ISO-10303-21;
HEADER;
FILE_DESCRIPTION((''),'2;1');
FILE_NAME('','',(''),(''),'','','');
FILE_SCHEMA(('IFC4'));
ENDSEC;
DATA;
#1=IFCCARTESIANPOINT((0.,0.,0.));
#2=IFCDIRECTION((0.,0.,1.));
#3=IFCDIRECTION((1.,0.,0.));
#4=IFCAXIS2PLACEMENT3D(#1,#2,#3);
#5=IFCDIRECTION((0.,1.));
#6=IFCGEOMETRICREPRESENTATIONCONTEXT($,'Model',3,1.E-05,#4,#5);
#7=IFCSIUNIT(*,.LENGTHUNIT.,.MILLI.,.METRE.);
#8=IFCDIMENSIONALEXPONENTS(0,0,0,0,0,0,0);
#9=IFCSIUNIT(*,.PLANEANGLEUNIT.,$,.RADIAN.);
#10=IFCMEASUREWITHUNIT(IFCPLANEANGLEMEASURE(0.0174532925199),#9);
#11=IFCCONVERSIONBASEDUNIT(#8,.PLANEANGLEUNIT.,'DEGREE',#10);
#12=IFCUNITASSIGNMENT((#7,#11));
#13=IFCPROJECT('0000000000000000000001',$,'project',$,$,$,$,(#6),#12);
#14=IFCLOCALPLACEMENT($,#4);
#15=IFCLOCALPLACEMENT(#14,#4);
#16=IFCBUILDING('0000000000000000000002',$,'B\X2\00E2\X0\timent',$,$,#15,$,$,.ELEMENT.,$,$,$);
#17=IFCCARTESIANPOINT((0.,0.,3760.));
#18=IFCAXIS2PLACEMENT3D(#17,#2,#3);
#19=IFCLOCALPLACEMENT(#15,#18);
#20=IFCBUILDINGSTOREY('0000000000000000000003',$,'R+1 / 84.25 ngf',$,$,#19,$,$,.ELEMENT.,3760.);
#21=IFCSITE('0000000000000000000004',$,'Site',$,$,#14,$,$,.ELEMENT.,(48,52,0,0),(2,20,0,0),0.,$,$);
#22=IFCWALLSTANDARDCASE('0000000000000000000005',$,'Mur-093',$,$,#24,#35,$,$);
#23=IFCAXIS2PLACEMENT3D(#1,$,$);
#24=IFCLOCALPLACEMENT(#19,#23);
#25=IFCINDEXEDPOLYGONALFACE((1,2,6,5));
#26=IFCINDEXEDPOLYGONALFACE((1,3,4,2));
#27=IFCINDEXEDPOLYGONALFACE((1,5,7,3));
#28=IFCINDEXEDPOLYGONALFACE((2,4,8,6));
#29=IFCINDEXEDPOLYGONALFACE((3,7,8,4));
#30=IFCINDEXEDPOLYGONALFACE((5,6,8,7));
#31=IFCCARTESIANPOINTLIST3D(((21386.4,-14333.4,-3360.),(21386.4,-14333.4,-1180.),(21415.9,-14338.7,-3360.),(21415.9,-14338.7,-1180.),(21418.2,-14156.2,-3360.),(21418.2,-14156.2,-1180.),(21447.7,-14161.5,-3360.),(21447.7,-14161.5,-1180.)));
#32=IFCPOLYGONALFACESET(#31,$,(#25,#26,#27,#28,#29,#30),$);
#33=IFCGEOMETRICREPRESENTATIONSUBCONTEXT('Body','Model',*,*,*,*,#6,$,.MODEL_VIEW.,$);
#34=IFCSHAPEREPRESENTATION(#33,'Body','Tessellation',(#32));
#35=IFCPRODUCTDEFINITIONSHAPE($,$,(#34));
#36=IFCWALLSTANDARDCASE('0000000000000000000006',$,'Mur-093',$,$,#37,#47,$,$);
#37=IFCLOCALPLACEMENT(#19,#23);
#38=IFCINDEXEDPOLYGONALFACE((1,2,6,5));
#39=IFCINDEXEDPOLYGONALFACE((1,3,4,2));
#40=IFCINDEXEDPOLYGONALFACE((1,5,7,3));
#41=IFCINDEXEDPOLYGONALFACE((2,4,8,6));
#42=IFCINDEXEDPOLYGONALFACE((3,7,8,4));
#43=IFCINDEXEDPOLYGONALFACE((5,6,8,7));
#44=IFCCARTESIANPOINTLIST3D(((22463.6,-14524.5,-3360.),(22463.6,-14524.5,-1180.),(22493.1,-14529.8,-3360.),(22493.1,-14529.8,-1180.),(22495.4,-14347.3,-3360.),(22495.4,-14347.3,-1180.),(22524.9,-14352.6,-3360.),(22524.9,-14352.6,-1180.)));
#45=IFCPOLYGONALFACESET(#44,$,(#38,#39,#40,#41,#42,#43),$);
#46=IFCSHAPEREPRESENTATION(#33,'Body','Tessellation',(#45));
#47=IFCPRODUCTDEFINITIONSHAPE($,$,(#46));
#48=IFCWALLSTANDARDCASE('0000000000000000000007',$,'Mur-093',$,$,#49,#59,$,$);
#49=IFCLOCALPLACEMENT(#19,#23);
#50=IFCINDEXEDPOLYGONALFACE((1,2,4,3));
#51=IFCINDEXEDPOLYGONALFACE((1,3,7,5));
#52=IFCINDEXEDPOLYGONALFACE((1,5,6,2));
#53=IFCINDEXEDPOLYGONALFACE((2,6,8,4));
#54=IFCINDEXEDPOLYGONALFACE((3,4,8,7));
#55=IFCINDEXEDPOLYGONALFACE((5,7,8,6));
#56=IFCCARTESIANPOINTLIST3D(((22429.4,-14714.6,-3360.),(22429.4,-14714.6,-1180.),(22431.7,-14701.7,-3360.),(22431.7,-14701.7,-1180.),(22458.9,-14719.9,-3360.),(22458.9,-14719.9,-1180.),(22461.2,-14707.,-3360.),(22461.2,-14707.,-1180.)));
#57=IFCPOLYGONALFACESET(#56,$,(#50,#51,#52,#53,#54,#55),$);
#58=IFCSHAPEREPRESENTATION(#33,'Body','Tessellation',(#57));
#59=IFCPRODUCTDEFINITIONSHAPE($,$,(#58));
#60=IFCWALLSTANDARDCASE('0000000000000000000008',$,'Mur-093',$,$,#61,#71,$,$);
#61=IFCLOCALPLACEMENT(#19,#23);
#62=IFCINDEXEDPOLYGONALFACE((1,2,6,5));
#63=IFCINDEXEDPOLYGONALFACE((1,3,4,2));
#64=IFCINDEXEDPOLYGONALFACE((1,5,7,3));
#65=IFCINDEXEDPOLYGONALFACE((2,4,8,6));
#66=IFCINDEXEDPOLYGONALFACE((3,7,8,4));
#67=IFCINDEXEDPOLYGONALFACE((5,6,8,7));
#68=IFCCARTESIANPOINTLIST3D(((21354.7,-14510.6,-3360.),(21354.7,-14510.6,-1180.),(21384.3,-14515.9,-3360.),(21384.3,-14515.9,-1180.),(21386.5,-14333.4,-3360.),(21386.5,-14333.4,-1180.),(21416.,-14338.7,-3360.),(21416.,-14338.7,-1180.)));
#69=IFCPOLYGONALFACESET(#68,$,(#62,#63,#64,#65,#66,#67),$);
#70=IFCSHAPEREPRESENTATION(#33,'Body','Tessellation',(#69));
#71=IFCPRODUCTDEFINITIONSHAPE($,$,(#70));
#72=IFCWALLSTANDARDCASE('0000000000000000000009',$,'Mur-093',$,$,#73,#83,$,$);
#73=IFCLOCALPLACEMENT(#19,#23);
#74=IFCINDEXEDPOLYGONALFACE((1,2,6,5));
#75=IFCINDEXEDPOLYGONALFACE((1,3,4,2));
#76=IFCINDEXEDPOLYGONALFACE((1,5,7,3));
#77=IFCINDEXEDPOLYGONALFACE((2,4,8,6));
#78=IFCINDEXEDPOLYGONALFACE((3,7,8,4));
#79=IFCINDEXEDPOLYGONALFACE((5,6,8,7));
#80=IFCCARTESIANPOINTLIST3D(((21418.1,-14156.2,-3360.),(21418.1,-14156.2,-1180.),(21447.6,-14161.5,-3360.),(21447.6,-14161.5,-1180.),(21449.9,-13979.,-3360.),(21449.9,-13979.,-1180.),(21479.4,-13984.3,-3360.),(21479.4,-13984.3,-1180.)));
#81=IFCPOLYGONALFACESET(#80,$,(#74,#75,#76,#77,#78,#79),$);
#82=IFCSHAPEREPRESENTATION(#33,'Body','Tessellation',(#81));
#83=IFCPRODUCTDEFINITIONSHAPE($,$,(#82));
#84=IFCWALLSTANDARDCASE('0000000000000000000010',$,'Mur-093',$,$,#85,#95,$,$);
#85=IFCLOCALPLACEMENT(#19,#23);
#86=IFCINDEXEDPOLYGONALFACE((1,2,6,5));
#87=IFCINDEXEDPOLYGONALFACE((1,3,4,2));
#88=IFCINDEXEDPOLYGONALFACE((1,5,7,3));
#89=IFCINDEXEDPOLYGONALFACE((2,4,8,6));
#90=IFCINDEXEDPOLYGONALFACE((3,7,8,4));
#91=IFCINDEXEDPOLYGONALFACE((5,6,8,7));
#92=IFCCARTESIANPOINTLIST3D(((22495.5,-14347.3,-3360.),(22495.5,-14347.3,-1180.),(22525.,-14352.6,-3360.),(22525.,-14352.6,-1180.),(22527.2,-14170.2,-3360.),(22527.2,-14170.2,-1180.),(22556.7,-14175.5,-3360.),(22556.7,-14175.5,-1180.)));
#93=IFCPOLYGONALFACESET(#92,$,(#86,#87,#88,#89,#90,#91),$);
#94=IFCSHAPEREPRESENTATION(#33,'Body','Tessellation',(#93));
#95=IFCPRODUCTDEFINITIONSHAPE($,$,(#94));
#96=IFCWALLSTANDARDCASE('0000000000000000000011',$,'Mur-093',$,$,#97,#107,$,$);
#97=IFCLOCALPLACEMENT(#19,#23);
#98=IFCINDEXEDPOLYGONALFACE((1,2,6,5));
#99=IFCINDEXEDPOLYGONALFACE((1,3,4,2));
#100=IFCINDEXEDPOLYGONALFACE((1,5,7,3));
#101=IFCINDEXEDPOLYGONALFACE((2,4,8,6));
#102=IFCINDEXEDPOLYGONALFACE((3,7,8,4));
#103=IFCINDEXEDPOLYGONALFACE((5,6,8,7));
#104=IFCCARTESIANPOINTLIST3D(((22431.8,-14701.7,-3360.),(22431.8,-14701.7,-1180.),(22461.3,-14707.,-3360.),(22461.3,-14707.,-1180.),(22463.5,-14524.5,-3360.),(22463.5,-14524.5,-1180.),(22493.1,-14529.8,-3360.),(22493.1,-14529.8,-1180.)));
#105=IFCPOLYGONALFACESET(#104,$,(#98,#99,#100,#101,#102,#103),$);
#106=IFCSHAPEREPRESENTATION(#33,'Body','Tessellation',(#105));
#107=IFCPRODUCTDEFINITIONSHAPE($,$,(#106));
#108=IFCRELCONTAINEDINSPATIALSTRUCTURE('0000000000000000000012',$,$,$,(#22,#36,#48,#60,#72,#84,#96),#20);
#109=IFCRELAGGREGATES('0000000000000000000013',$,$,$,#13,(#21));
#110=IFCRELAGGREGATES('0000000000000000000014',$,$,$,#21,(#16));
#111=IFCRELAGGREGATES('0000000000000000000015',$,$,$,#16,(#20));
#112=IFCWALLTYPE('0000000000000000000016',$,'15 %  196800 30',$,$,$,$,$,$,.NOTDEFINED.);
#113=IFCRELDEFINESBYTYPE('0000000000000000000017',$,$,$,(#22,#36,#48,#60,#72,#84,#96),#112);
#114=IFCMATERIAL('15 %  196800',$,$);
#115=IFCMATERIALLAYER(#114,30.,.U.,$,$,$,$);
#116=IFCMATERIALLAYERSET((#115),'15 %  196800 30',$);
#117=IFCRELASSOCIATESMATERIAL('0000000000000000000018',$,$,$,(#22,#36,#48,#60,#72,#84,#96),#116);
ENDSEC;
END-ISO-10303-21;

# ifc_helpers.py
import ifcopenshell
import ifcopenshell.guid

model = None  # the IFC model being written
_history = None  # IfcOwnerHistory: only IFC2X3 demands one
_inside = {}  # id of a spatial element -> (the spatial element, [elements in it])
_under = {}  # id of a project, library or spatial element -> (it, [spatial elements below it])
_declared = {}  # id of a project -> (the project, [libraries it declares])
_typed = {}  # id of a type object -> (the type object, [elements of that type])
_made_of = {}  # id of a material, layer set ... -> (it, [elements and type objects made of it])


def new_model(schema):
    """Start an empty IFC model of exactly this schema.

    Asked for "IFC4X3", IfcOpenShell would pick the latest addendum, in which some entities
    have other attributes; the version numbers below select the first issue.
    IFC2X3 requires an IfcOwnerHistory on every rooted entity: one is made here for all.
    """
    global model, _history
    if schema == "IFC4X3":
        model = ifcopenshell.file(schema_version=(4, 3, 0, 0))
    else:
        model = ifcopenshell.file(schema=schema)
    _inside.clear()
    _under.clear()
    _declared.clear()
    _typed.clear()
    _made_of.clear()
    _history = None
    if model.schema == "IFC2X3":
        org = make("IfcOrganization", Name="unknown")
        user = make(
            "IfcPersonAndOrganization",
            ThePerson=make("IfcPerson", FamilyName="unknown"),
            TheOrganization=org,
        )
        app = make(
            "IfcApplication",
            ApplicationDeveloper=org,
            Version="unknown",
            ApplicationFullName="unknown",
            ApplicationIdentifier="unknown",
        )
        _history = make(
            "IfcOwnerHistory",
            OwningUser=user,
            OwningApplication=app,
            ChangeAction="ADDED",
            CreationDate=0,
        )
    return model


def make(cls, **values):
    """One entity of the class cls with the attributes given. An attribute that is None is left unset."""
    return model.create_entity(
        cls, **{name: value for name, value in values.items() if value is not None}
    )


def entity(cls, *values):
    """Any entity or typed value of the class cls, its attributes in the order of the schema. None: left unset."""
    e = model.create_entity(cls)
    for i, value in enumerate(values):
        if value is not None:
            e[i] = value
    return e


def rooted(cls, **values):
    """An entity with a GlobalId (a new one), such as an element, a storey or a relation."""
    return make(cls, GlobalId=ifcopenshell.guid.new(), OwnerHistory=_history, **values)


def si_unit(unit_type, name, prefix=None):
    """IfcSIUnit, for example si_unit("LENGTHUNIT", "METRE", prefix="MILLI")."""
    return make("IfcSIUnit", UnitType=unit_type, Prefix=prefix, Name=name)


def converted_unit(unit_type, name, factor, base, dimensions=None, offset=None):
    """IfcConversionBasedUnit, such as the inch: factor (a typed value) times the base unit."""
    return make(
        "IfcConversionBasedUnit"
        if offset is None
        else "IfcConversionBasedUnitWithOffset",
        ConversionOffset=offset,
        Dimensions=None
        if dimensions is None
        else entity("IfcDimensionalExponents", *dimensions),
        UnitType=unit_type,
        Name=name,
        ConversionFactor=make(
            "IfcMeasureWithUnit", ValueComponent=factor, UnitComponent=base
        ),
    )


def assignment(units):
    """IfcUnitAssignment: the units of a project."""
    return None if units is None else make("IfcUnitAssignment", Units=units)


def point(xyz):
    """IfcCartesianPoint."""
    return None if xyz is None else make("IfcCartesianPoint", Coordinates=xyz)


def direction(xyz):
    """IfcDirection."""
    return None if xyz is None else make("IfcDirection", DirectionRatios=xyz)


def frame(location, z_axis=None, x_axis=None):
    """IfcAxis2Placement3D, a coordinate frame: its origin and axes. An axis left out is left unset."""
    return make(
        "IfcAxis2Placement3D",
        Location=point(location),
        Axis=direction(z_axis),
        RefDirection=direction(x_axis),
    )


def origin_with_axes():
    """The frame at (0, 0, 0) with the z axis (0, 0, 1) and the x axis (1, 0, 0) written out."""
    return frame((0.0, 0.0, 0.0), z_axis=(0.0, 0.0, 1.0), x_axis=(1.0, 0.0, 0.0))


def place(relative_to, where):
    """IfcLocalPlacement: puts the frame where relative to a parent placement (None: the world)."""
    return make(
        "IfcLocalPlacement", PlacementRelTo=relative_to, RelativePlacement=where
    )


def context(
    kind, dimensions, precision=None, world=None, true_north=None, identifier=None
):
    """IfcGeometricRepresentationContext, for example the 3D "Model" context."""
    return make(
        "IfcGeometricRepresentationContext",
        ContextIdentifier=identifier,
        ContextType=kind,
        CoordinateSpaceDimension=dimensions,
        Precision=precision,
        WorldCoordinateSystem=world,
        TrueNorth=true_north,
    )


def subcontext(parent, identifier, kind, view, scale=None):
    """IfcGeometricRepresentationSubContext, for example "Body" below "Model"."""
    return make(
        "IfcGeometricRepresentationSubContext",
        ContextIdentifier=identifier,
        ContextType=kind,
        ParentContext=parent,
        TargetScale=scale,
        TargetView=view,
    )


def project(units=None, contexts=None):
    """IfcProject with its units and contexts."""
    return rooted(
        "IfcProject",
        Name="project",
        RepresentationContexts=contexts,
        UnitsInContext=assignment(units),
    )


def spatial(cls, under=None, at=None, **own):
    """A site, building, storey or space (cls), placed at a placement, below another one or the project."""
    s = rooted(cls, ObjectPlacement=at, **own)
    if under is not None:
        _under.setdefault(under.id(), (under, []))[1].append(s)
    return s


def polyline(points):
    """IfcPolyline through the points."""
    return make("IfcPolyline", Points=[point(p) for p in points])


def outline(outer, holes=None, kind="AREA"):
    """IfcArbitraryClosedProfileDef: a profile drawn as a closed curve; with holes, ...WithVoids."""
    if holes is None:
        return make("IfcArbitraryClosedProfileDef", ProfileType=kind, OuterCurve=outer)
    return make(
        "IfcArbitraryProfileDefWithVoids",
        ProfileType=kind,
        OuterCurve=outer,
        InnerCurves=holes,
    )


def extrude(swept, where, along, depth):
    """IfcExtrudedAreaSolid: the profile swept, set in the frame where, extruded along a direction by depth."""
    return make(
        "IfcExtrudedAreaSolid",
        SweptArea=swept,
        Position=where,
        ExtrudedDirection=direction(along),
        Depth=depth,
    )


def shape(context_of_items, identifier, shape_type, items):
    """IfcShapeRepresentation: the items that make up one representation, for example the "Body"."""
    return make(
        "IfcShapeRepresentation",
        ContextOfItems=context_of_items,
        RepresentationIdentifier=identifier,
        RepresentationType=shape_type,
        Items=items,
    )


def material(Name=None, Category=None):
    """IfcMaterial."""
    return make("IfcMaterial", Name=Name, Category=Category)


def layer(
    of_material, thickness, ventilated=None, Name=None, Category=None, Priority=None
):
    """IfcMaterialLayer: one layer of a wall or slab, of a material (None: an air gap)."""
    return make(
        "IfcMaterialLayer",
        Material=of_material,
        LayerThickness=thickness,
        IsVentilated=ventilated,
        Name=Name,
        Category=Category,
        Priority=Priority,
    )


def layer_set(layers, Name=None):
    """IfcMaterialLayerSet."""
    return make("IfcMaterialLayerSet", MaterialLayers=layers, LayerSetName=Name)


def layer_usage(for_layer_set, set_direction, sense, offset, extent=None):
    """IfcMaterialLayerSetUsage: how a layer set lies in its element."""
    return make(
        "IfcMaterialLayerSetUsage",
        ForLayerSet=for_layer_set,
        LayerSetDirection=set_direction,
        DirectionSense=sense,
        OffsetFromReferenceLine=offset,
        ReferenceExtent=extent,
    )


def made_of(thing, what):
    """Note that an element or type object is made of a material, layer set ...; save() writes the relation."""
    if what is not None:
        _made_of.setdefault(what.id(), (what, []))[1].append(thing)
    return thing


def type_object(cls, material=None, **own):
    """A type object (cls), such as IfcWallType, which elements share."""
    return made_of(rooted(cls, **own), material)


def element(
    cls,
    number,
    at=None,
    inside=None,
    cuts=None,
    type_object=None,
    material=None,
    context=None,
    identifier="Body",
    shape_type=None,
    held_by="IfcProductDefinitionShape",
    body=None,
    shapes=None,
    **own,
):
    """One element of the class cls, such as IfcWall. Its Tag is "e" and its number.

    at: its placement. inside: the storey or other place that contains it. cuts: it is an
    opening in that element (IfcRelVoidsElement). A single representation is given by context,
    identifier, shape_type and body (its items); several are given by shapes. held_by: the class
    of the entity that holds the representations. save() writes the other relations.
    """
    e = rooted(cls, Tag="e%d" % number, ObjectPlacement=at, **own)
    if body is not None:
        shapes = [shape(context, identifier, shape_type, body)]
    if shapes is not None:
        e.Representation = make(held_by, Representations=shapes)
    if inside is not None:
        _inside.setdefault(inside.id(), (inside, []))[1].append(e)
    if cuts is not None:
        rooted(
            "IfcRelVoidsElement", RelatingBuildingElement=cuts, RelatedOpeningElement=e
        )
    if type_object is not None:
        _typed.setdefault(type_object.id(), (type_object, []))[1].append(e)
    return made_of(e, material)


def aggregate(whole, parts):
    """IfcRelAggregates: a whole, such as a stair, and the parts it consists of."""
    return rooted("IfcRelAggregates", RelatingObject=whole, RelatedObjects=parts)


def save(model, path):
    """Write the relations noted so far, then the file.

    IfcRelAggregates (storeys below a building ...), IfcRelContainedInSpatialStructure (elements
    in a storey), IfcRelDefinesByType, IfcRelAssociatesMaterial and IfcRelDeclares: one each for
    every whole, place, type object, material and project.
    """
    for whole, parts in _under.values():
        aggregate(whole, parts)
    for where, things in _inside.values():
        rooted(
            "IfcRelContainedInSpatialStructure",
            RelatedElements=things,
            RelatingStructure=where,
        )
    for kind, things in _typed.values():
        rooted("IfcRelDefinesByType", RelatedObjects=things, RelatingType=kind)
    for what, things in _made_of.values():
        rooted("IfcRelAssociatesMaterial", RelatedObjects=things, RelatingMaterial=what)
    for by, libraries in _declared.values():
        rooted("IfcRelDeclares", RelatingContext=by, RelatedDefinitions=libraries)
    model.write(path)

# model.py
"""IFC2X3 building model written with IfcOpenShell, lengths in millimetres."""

from ifc_helpers import new_model, entity, si_unit, converted_unit, direction, frame, origin_with_axes, place, context, subcontext, project, spatial, polyline, outline, extrude, material, layer, layer_set, layer_usage, type_object, element, save


model = new_model("IFC2X3")

# Units and contexts
model_context = context("Model", 3, precision=1e-05, world=origin_with_axes(), true_north=direction((0.0, 1.0)))
body_context = subcontext(model_context, "Body", "Model", "MODEL_VIEW")
ifc_project = project(units=[si_unit("LENGTHUNIT", "METRE", prefix="MILLI"), converted_unit("PLANEANGLEUNIT", "DEGREE", entity("IfcPlaneAngleMeasure", 0.0174532925199), si_unit("PLANEANGLEUNIT", "RADIAN"), dimensions=[0, 0, 0, 0, 0, 0, 0])], contexts=[model_context])

# Site, building, storey
site_placement = place(None, origin_with_axes())
site = spatial("IfcSite", under=ifc_project, at=site_placement, Name="Site", CompositionType="ELEMENT", RefLatitude=(48, 52, 0, 0), RefLongitude=(2, 20, 0, 0), RefElevation=0.0)
building_placement = place(site_placement, origin_with_axes())
building = spatial("IfcBuilding", under=site, at=building_placement, Name="Bâtiment", CompositionType="ELEMENT")
storey_placement = place(building_placement, frame((0.0, 0.0, 3760.0), z_axis=(0.0, 0.0, 1.0), x_axis=(1.0, 0.0, 0.0)))
storey = spatial("IfcBuildingStorey", under=building, at=storey_placement, Name="R+1 / 84.25 ngf", CompositionType="ELEMENT", Elevation=3760.0)

# Shared definitions
ifc_material = material(Name="15 %  196800")
ifc_layer = layer(ifc_material, 30.0, ventilated="UNKNOWN")
ifc_layer_set = layer_set([ifc_layer], Name="15 %  196800 30")

# Walls
wall_type = type_object("IfcWallType", Name="15 %  196800 30", PredefinedType="NOTDEFINED")
ifc_layer_usage_1 = layer_usage(ifc_layer_set, "AXIS2", "NEGATIVE", 30.0)
wall_1_placement = place(storey_placement, frame((21418.2, -14156.2, -3360.0), z_axis=(0.0, 0.0, 1.0), x_axis=(-0.176462, -0.984308, 0.0)))
element("IfcWallStandardCase", 1, at=wall_1_placement, inside=storey, type_object=wall_type, material=ifc_layer_usage_1, Name="Mur-093", context=body_context, shape_type="SweptSolid", body=[
    extrude(outline(polyline([(0.0, 0.0), (180.0, 0.0), (180.0, 30.0), (0.0, 30.0), (0.0, 0.0)])), origin_with_axes(), (0.0, 0.0, 1.0), 2180.0),
])
ifc_layer_usage_2 = layer_usage(ifc_layer_set, "AXIS2", "POSITIVE", -30.0)
wall_2_placement = place(storey_placement, frame((22524.9, -14352.6, -3360.0), z_axis=(0.0, 0.0, 1.0), x_axis=(-0.176462, -0.984308, 0.0)))
element("IfcWallStandardCase", 2, at=wall_2_placement, inside=storey, type_object=wall_type, material=ifc_layer_usage_2, Name="Mur-093", context=body_context, shape_type="SweptSolid", body=[
    extrude(outline(polyline([(0.0, -30.0), (180.0, -30.0), (180.0, 0.0), (0.0, 0.0), (0.0, -30.0)])), origin_with_axes(), (0.0, 0.0, 1.0), 2180.0),
])
ifc_layer_usage_3 = layer_usage(ifc_layer_set, "AXIS2", "POSITIVE", -30.0)
wall_3_placement = place(storey_placement, frame((22461.2, -14707.0, -3360.0), z_axis=(0.0, 0.0, 1.0), x_axis=(-0.176462, -0.984308, 0.0)))
element("IfcWallStandardCase", 3, at=wall_3_placement, inside=storey, type_object=wall_type, material=ifc_layer_usage_3, Name="Mur-093", context=body_context, shape_type="SweptSolid", body=[
    extrude(outline(polyline([(0.0, -30.0), (13.1, -30.0), (13.1, 0.0), (0.0, 0.0), (0.0, -30.0)])), origin_with_axes(), (0.0, 0.0, 1.0), 2180.0),
])
ifc_layer_usage_4 = layer_usage(ifc_layer_set, "AXIS2", "NEGATIVE", 30.0)
wall_4_placement = place(storey_placement, frame((21386.5, -14333.4, -3360.0), z_axis=(0.0, 0.0, 1.0), x_axis=(-0.176462, -0.984308, 0.0)))
element("IfcWallStandardCase", 4, at=wall_4_placement, inside=storey, type_object=wall_type, material=ifc_layer_usage_4, Name="Mur-093", context=body_context, shape_type="SweptSolid", body=[
    extrude(outline(polyline([(0.0, 0.0), (180.0, 0.0), (180.0, 30.0), (0.0, 30.0), (0.0, 0.0)])), origin_with_axes(), (0.0, 0.0, 1.0), 2180.0),
])
ifc_layer_usage_5 = layer_usage(ifc_layer_set, "AXIS2", "NEGATIVE", 30.0)
wall_5_placement = place(storey_placement, frame((21449.9, -13979.0, -3360.0), z_axis=(0.0, 0.0, 1.0), x_axis=(-0.176462, -0.984308, 0.0)))
element("IfcWallStandardCase", 5, at=wall_5_placement, inside=storey, type_object=wall_type, material=ifc_layer_usage_5, Name="Mur-093", context=body_context, shape_type="SweptSolid", body=[
    extrude(outline(polyline([(0.0, 0.0), (180.0, 0.0), (180.0, 30.0), (0.0, 30.0), (0.0, 0.0)])), origin_with_axes(), (0.0, 0.0, 1.0), 2180.0),
])
ifc_layer_usage_6 = layer_usage(ifc_layer_set, "AXIS2", "POSITIVE", -30.0)
wall_6_placement = place(storey_placement, frame((22556.7, -14175.5, -3360.0), z_axis=(0.0, 0.0, 1.0), x_axis=(-0.176462, -0.984308, 0.0)))
element("IfcWallStandardCase", 6, at=wall_6_placement, inside=storey, type_object=wall_type, material=ifc_layer_usage_6, Name="Mur-093", context=body_context, shape_type="SweptSolid", body=[
    extrude(outline(polyline([(0.0, -30.0), (180.0, -30.0), (180.0, 0.0), (0.0, 0.0), (0.0, -30.0)])), origin_with_axes(), (0.0, 0.0, 1.0), 2180.0),
])
ifc_layer_usage_7 = layer_usage(ifc_layer_set, "AXIS2", "POSITIVE", -30.0)
wall_7_placement = place(storey_placement, frame((22493.1, -14529.8, -3360.0), z_axis=(0.0, 0.0, 1.0), x_axis=(-0.176462, -0.984308, 0.0)))
element("IfcWallStandardCase", 7, at=wall_7_placement, inside=storey, type_object=wall_type, material=ifc_layer_usage_7, Name="Mur-093", context=body_context, shape_type="SweptSolid", body=[
    extrude(outline(polyline([(0.0, -30.0), (180.0, -30.0), (180.0, 0.0), (0.0, 0.0), (0.0, -30.0)])), origin_with_axes(), (0.0, 0.0, 1.0), 2180.0),
])

save(model, "model.ifc")
